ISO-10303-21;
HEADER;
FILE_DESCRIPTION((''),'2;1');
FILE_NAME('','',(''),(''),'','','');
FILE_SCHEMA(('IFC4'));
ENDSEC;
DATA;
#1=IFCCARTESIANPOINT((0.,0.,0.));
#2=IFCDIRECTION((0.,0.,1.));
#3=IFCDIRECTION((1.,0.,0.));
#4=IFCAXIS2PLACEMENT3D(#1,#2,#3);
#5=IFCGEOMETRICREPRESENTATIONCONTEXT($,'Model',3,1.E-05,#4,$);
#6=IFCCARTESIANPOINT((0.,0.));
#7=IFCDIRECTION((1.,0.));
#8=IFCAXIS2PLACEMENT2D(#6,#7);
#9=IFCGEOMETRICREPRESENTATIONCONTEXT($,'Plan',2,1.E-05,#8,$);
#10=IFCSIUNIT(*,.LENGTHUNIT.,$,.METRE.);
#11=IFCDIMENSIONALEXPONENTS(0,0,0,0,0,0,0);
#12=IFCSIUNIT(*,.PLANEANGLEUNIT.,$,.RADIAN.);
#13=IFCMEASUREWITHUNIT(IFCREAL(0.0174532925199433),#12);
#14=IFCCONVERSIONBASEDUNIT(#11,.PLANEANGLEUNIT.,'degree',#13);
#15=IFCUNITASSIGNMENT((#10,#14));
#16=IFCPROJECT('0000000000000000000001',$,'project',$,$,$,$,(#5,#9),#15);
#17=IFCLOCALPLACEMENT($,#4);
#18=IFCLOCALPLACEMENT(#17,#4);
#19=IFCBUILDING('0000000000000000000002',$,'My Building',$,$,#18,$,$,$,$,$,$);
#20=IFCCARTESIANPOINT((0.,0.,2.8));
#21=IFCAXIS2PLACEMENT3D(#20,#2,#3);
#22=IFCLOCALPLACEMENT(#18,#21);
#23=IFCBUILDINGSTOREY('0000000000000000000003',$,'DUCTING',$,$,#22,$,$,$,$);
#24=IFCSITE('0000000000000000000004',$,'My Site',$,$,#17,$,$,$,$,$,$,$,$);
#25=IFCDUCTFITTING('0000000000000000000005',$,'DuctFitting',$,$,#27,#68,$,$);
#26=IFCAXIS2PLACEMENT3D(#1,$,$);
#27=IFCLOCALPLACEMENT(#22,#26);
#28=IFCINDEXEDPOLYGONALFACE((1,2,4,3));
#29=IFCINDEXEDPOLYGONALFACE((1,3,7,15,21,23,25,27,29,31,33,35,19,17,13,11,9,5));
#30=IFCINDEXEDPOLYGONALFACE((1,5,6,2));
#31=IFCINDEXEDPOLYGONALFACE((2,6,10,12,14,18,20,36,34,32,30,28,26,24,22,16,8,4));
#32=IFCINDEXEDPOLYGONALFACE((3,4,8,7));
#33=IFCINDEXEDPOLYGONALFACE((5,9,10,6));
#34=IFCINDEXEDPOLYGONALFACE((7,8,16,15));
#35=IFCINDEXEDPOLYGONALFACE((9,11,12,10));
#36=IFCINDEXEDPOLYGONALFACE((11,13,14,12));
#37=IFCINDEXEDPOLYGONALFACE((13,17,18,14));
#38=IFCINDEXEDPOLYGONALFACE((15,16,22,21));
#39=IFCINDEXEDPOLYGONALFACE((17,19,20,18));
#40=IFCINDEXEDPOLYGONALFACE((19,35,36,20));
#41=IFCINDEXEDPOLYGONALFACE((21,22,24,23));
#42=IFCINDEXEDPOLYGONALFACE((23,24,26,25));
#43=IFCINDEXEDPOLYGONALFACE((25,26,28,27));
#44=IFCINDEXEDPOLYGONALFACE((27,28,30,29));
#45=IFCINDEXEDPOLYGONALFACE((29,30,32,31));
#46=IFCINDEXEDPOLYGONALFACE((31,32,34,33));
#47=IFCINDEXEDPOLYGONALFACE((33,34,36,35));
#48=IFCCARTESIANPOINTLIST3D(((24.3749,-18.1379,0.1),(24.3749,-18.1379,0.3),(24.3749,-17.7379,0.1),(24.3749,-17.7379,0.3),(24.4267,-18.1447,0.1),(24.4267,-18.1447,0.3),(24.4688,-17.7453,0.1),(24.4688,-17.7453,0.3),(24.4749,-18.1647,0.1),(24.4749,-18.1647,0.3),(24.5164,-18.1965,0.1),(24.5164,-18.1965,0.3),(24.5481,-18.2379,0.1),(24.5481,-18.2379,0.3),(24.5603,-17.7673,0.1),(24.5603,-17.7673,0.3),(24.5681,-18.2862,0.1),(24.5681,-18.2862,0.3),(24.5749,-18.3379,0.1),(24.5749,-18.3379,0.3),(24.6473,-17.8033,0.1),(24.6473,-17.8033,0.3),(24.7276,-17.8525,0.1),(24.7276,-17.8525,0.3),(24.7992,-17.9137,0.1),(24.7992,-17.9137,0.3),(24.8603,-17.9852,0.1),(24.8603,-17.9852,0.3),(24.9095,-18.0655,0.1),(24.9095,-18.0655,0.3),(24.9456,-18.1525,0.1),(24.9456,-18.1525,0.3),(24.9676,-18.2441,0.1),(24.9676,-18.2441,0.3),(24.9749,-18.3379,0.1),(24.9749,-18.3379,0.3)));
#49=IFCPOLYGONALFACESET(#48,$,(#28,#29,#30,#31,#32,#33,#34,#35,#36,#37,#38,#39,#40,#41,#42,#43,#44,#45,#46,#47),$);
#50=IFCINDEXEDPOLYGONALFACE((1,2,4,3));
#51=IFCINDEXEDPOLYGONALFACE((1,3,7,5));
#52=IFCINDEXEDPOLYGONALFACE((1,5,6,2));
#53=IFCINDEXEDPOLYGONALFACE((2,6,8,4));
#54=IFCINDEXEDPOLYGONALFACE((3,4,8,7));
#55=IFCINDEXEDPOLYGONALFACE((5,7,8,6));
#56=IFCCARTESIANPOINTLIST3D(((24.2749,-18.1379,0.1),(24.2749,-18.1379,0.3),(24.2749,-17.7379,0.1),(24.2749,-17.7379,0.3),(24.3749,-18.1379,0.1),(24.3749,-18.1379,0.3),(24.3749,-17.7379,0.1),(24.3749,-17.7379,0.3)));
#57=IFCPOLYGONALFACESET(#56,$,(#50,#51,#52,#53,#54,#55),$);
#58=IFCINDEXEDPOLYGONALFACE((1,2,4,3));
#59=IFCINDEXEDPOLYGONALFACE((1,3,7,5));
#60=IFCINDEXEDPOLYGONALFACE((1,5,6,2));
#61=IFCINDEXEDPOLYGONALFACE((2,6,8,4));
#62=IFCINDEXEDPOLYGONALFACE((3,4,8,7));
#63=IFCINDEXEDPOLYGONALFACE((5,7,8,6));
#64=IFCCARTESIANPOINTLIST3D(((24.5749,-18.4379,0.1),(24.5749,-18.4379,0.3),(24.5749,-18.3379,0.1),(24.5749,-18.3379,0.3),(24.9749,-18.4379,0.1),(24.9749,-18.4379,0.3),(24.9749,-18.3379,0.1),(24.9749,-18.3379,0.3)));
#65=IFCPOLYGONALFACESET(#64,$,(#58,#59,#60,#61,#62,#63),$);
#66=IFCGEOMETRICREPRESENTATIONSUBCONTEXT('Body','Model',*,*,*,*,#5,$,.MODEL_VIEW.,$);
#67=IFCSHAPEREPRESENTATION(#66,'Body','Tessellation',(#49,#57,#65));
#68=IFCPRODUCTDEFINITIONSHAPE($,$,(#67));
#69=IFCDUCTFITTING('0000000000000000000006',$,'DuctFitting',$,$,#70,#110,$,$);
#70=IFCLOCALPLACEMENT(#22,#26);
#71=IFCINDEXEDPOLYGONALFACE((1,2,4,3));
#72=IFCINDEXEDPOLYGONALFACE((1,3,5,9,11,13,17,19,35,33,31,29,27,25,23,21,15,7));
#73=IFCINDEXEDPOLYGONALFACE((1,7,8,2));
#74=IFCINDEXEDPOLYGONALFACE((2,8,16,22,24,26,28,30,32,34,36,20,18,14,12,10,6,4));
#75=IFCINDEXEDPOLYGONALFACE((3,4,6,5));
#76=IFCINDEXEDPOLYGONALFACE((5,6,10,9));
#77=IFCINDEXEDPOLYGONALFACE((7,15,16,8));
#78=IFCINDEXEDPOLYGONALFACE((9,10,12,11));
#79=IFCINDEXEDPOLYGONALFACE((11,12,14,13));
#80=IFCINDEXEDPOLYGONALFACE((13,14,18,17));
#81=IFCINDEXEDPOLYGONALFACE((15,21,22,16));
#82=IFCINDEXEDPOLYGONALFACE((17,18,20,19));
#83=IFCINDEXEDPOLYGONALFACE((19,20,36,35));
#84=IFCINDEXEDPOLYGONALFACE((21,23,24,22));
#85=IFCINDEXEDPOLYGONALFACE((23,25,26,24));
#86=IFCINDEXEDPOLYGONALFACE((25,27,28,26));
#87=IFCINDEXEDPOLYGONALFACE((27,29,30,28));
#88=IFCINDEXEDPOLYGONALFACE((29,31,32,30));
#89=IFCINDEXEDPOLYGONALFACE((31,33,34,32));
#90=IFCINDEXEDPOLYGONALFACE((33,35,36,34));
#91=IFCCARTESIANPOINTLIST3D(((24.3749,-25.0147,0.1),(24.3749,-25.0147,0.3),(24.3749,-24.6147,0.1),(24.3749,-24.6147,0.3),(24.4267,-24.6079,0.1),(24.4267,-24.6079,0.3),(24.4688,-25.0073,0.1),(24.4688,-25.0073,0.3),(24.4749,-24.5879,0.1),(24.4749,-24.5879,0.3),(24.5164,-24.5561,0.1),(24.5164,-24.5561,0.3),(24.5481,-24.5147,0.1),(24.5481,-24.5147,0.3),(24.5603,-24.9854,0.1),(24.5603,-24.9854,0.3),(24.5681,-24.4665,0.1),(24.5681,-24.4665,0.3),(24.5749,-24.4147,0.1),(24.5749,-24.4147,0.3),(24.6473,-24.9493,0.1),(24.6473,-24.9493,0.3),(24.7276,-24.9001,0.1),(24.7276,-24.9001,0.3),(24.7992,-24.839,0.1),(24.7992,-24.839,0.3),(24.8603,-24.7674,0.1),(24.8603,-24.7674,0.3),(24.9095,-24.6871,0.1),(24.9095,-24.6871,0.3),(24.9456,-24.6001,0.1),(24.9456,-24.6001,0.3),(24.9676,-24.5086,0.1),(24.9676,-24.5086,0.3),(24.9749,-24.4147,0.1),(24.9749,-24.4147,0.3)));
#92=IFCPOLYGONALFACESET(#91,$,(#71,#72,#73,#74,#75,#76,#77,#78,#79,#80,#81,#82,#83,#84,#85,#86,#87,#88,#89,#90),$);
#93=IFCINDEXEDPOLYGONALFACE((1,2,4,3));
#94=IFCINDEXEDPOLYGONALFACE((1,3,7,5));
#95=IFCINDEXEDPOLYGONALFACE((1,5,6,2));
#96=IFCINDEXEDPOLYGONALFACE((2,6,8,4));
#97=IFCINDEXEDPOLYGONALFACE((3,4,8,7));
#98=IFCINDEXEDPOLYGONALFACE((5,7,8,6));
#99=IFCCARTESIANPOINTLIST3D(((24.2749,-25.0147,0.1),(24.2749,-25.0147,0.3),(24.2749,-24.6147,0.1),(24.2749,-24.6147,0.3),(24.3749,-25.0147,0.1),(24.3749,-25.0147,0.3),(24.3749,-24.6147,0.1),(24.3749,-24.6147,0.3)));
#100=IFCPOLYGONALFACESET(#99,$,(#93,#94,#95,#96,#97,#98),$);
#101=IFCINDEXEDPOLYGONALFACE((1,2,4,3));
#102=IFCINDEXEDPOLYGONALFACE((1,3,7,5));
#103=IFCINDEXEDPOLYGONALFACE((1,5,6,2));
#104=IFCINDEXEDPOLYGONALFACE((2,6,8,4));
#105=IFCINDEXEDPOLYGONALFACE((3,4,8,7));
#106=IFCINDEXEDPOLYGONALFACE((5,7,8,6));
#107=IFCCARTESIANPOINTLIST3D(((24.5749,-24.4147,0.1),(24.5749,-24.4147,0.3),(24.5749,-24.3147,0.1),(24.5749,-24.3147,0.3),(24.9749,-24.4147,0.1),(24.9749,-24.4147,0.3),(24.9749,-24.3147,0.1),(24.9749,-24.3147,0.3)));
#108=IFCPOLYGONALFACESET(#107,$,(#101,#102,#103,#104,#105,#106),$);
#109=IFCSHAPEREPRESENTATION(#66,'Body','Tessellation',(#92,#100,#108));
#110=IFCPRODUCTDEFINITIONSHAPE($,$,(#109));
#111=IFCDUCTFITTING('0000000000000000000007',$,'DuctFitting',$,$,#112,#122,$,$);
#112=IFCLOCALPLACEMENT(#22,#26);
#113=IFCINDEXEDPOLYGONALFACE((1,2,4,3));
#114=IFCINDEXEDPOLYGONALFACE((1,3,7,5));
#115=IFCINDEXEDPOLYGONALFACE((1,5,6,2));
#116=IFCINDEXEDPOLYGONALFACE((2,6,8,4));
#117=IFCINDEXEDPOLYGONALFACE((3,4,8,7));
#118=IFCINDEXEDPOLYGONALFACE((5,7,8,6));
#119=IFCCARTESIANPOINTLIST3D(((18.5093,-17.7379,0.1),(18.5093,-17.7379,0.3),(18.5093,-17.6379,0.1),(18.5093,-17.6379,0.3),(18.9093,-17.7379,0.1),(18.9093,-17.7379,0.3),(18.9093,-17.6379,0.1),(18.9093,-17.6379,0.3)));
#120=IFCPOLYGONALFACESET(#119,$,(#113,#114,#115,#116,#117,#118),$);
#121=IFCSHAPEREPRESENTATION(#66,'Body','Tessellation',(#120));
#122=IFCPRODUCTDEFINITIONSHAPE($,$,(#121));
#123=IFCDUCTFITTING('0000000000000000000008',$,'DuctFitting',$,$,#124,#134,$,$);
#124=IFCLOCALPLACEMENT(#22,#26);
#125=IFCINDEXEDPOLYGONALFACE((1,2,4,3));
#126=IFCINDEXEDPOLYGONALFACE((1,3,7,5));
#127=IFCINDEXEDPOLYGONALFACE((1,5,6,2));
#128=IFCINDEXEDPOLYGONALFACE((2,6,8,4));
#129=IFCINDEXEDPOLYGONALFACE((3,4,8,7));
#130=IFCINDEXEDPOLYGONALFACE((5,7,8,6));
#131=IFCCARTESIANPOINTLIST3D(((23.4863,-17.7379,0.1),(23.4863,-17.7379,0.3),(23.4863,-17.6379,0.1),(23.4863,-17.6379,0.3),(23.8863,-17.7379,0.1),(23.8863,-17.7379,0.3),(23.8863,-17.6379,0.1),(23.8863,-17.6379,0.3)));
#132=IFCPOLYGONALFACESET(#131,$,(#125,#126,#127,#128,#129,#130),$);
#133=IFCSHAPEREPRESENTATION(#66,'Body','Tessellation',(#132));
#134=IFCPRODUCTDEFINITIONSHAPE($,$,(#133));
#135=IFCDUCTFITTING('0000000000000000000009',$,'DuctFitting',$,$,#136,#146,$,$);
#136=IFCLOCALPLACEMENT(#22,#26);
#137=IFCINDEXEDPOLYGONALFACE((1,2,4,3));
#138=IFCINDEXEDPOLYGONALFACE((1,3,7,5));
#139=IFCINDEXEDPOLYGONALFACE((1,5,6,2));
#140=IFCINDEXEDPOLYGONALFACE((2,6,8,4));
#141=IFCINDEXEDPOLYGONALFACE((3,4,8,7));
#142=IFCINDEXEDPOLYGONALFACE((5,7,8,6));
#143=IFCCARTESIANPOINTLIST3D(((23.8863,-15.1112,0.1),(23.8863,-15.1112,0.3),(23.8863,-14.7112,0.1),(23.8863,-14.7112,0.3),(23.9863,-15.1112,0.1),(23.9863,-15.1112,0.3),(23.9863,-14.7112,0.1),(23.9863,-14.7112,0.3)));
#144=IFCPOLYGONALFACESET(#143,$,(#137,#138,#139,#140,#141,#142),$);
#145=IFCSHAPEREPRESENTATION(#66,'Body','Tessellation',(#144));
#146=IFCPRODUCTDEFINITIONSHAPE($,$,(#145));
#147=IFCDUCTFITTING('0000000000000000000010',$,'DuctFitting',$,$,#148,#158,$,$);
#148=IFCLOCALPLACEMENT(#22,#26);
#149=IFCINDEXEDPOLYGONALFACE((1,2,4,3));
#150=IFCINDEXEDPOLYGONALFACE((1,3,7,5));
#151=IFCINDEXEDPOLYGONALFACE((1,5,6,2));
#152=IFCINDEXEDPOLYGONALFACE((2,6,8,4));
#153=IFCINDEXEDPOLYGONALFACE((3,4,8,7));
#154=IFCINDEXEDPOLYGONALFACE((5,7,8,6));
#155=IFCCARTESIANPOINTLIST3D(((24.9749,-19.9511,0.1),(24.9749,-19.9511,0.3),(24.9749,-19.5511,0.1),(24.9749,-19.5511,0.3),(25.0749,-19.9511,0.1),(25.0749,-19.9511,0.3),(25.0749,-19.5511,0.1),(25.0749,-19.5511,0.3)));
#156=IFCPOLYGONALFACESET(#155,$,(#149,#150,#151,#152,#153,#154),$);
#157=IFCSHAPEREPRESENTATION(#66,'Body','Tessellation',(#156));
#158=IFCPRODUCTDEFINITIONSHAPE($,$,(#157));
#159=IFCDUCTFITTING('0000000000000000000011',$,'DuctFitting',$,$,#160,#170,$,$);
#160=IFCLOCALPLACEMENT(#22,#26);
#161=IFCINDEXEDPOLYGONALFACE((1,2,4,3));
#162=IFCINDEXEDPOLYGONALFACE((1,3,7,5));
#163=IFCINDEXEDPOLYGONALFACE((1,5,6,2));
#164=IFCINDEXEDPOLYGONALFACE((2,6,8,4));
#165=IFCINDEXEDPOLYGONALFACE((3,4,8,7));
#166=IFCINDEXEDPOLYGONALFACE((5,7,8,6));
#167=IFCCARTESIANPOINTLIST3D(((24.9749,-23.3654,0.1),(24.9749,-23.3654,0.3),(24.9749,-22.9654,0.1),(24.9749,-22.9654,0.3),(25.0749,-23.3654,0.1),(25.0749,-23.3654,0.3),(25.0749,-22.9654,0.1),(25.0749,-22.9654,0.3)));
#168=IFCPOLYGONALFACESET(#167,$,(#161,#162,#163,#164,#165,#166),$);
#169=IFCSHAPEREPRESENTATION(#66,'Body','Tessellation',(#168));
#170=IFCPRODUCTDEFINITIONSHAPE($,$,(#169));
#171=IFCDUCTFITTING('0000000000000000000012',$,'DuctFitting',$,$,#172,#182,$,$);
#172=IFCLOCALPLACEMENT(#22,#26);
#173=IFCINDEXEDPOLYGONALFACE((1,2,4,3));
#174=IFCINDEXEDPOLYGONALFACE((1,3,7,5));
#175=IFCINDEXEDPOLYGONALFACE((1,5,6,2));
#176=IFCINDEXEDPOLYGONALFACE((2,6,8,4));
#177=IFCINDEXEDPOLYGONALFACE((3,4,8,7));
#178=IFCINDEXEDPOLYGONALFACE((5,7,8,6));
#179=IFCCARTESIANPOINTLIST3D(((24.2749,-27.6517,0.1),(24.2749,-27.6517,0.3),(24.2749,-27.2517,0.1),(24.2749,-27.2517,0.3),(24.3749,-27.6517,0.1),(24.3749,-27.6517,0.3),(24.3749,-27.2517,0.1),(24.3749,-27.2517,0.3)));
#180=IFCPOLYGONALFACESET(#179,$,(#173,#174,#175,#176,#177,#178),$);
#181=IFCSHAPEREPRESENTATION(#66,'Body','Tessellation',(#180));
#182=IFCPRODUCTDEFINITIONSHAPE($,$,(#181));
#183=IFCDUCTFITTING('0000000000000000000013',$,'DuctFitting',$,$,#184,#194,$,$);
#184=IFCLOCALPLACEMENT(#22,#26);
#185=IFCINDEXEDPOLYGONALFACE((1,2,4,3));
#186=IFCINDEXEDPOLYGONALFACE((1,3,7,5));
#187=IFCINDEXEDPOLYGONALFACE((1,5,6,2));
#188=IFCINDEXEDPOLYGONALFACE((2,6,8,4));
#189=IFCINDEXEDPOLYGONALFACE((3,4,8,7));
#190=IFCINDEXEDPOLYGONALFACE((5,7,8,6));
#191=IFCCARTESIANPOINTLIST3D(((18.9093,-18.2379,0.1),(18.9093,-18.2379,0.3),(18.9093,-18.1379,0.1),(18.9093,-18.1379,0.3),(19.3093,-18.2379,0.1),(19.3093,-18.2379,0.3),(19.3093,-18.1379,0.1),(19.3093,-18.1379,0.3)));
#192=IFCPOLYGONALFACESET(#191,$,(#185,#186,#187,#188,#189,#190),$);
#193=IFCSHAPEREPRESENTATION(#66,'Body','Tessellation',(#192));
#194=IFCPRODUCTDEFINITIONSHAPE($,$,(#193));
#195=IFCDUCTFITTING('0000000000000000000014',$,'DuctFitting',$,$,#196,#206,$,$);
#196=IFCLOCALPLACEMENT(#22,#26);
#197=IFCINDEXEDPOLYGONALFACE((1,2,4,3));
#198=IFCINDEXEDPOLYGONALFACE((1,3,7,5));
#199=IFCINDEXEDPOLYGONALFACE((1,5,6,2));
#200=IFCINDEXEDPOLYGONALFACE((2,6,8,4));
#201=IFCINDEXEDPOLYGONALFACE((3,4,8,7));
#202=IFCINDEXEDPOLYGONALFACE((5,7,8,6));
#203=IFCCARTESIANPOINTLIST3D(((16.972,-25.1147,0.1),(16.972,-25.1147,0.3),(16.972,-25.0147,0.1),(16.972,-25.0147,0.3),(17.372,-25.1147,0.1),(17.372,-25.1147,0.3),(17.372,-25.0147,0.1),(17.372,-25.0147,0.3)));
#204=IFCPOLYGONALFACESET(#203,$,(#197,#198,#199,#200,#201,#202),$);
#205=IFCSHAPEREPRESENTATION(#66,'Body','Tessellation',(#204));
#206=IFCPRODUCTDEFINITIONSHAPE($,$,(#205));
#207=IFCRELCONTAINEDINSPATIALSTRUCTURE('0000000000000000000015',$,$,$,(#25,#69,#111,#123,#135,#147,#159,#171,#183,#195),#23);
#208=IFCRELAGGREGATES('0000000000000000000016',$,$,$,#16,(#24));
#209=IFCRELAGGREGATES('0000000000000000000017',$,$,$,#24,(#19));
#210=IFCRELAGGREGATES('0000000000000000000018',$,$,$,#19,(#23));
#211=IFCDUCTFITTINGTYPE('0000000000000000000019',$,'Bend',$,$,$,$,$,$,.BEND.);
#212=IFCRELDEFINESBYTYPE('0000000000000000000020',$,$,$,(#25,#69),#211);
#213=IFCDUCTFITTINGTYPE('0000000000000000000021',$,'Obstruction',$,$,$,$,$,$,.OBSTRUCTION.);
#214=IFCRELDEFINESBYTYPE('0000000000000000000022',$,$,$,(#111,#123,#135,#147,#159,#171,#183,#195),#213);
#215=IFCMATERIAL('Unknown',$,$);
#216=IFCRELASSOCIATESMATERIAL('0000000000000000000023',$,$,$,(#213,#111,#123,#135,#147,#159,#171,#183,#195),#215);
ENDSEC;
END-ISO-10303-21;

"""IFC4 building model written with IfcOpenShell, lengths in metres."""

from ifc_helpers import new_model, entity, si_unit, converted_unit, frame, origin_with_axes, origin_2d_with_axis, place, context, subcontext, project, spatial, line, arc, indexed_curve, rectangle, outline, extrude, source, transform, mapped, material, material_profile, profile_set, profile_usage, type_object, type_shapes, element, save


model = new_model("IFC4")

# Units and contexts
model_context = context("Model", 3, precision=1e-05, world=origin_with_axes())
plan_context = context("Plan", 2, precision=1e-05, world=origin_2d_with_axis())
body_context = subcontext(model_context, "Body", "Model", "MODEL_VIEW")
ifc_project = project(units=[si_unit("LENGTHUNIT", "METRE"), converted_unit("PLANEANGLEUNIT", "degree", entity("IfcReal", 0.0174532925199433), si_unit("PLANEANGLEUNIT", "RADIAN"), dimensions=[0, 0, 0, 0, 0, 0, 0])], contexts=[model_context, plan_context])

# Site, building, storey
site_placement = place(None, origin_with_axes())
site = spatial("IfcSite", under=ifc_project, at=site_placement, Name="My Site")
building_placement = place(site_placement, origin_with_axes())
building = spatial("IfcBuilding", under=site, at=building_placement, Name="My Building")
storey_placement = place(building_placement, frame((0.0, 0.0, 2.8), z_axis=(0.0, 0.0, 1.0), x_axis=(1.0, 0.0, 0.0)))
storey = spatial("IfcBuildingStorey", under=building, at=storey_placement, Name="DUCTING")

# Shared definitions
ifc_material = material(Name="Unknown")

# Duct fittings
duct_fitting_type_1 = type_object("IfcDuctFittingType", Name="Bend", PredefinedType="BEND")
shared_shape = source(origin_with_axes(), body_context, "Body", "SweptSolid", [
    extrude(outline(indexed_curve([(-0.2, 0.0), (-0.2586, -0.1414), (-0.4, -0.2), (-0.4, -0.6), (0.0243, -0.4243), (0.2, 0.0)], segments=[arc(1, 2, 3), line(3, 4), arc(4, 5, 6), line(6, 1)])), frame((0.0, -0.1, -0.1), z_axis=(0.0, -1.0, 0.0), x_axis=(1.0, 0.0, 0.0)), (0.0, 0.0, -1.0), 0.2),
    extrude(rectangle(XDim=0.4, YDim=0.2), origin_with_axes(), (0.0, 0.0, -1.0), 0.1),
    extrude(rectangle(XDim=0.4, YDim=0.2), frame((-0.4, 0.0, -0.5), z_axis=(-1.0, 0.0, 0.0), x_axis=(0.0, 0.0, -1.0)), (0.0, 0.0, 1.0), 0.1),
])
type_shapes(duct_fitting_type_1, [shared_shape])
for number, where, z_axis, x_axis, name in (
    (1, (24.2749, -17.9379, 0.2), (-1.0, 0.0, 0.0), (0.0, 1.0, 0.0), "DuctFitting"),
    (2, (24.2749, -24.8147, 0.2), (-1.0, 0.0, 0.0), (0.0, -1.0, 0.0), "DuctFitting"),
):
    element("IfcDuctFitting", number, at=place(storey_placement, frame(where, z_axis=z_axis, x_axis=x_axis)), inside=storey, type_object=duct_fitting_type_1, Name=name, context=body_context, shape_type="MappedRepresentation", body=[
        mapped(shared_shape, transform((0.0, 0.0, 0.0), x_axis=(1.0, 0.0, 0.0), y_axis=(0.0, 1.0, 0.0), z_axis=(0.0, 0.0, 1.0), scale=1.0)),
    ])
ifc_material_profile_1 = material_profile(ifc_material, rectangle(XDim=0.4, YDim=0.2))
ifc_profile_set_1 = profile_set([ifc_material_profile_1])
ifc_profile_usage_1 = profile_usage(ifc_profile_set_1, cardinal=5)
duct_fitting_type_2 = type_object("IfcDuctFittingType", Name="Obstruction", PredefinedType="OBSTRUCTION", material=ifc_profile_set_1)
duct_fitting_1_placement = place(storey_placement, frame((18.7093, -17.7379, 0.2), z_axis=(0.0, 1.0, 0.0), x_axis=(-1.0, 0.0, 0.0)))
element("IfcDuctFitting", 3, at=duct_fitting_1_placement, inside=storey, type_object=duct_fitting_type_2, material=ifc_profile_usage_1, Name="DuctFitting", context=body_context, shape_type="SweptSolid", body=[
    extrude(rectangle(XDim=0.4, YDim=0.2), origin_with_axes(), (0.0, 0.0, 1.0), 0.1),
])
ifc_profile_usage_2 = profile_usage(ifc_profile_set_1, cardinal=5)
duct_fitting_2_placement = place(storey_placement, frame((23.6863, -17.7379, 0.2), z_axis=(0.0, 1.0, 0.0), x_axis=(-1.0, 0.0, 0.0)))
element("IfcDuctFitting", 4, at=duct_fitting_2_placement, inside=storey, type_object=duct_fitting_type_2, material=ifc_profile_usage_2, Name="DuctFitting", context=body_context, shape_type="SweptSolid", body=[
    extrude(rectangle(XDim=0.4, YDim=0.2), origin_with_axes(), (0.0, 0.0, 1.0), 0.1),
])
ifc_profile_usage_3 = profile_usage(ifc_profile_set_1, cardinal=5)
duct_fitting_3_placement = place(storey_placement, frame((23.8863, -14.9112, 0.2), z_axis=(1.0, 0.0, 0.0), x_axis=(0.0, 1.0, 0.0)))
element("IfcDuctFitting", 5, at=duct_fitting_3_placement, inside=storey, type_object=duct_fitting_type_2, material=ifc_profile_usage_3, Name="DuctFitting", context=body_context, shape_type="SweptSolid", body=[
    extrude(rectangle(XDim=0.4, YDim=0.2), origin_with_axes(), (0.0, 0.0, 1.0), 0.1),
])
ifc_profile_usage_4 = profile_usage(ifc_profile_set_1, cardinal=5)
duct_fitting_4_placement = place(storey_placement, frame((24.9749, -19.7511, 0.2), z_axis=(1.0, 0.0, 0.0), x_axis=(0.0, 1.0, 0.0)))
element("IfcDuctFitting", 6, at=duct_fitting_4_placement, inside=storey, type_object=duct_fitting_type_2, material=ifc_profile_usage_4, Name="DuctFitting", context=body_context, shape_type="SweptSolid", body=[
    extrude(rectangle(XDim=0.4, YDim=0.2), origin_with_axes(), (0.0, 0.0, 1.0), 0.1),
])
ifc_profile_usage_5 = profile_usage(ifc_profile_set_1, cardinal=5)
duct_fitting_5_placement = place(storey_placement, frame((24.9749, -23.1654, 0.2), z_axis=(1.0, 0.0, 0.0), x_axis=(0.0, 1.0, 0.0)))
element("IfcDuctFitting", 7, at=duct_fitting_5_placement, inside=storey, type_object=duct_fitting_type_2, material=ifc_profile_usage_5, Name="DuctFitting", context=body_context, shape_type="SweptSolid", body=[
    extrude(rectangle(XDim=0.4, YDim=0.2), origin_with_axes(), (0.0, 0.0, 1.0), 0.1),
])
ifc_profile_usage_6 = profile_usage(ifc_profile_set_1, cardinal=5)
duct_fitting_6_placement = place(storey_placement, frame((24.2749, -27.4517, 0.2), z_axis=(1.0, 0.0, 0.0), x_axis=(0.0, 1.0, 0.0)))
element("IfcDuctFitting", 8, at=duct_fitting_6_placement, inside=storey, type_object=duct_fitting_type_2, material=ifc_profile_usage_6, Name="DuctFitting", context=body_context, shape_type="SweptSolid", body=[
    extrude(rectangle(XDim=0.4, YDim=0.2), origin_with_axes(), (0.0, 0.0, 1.0), 0.1),
])
ifc_profile_usage_7 = profile_usage(ifc_profile_set_1, cardinal=5)
duct_fitting_7_placement = place(storey_placement, frame((19.1093, -18.1379, 0.2), z_axis=(0.0, -1.0, 0.0), x_axis=(1.0, 0.0, 0.0)))
element("IfcDuctFitting", 9, at=duct_fitting_7_placement, inside=storey, type_object=duct_fitting_type_2, material=ifc_profile_usage_7, Name="DuctFitting", context=body_context, shape_type="SweptSolid", body=[
    extrude(rectangle(XDim=0.4, YDim=0.2), origin_with_axes(), (0.0, 0.0, 1.0), 0.1),
])
ifc_profile_usage_8 = profile_usage(ifc_profile_set_1, cardinal=5)
duct_fitting_8_placement = place(storey_placement, frame((17.172, -25.0147, 0.2), z_axis=(0.0, -1.0, 0.0), x_axis=(1.0, 0.0, 0.0)))
element("IfcDuctFitting", 10, at=duct_fitting_8_placement, inside=storey, type_object=duct_fitting_type_2, material=ifc_profile_usage_8, Name="DuctFitting", context=body_context, shape_type="SweptSolid", body=[
    extrude(rectangle(XDim=0.4, YDim=0.2), origin_with_axes(), (0.0, 0.0, 1.0), 0.1),
])

save(model, "model.ifc")
